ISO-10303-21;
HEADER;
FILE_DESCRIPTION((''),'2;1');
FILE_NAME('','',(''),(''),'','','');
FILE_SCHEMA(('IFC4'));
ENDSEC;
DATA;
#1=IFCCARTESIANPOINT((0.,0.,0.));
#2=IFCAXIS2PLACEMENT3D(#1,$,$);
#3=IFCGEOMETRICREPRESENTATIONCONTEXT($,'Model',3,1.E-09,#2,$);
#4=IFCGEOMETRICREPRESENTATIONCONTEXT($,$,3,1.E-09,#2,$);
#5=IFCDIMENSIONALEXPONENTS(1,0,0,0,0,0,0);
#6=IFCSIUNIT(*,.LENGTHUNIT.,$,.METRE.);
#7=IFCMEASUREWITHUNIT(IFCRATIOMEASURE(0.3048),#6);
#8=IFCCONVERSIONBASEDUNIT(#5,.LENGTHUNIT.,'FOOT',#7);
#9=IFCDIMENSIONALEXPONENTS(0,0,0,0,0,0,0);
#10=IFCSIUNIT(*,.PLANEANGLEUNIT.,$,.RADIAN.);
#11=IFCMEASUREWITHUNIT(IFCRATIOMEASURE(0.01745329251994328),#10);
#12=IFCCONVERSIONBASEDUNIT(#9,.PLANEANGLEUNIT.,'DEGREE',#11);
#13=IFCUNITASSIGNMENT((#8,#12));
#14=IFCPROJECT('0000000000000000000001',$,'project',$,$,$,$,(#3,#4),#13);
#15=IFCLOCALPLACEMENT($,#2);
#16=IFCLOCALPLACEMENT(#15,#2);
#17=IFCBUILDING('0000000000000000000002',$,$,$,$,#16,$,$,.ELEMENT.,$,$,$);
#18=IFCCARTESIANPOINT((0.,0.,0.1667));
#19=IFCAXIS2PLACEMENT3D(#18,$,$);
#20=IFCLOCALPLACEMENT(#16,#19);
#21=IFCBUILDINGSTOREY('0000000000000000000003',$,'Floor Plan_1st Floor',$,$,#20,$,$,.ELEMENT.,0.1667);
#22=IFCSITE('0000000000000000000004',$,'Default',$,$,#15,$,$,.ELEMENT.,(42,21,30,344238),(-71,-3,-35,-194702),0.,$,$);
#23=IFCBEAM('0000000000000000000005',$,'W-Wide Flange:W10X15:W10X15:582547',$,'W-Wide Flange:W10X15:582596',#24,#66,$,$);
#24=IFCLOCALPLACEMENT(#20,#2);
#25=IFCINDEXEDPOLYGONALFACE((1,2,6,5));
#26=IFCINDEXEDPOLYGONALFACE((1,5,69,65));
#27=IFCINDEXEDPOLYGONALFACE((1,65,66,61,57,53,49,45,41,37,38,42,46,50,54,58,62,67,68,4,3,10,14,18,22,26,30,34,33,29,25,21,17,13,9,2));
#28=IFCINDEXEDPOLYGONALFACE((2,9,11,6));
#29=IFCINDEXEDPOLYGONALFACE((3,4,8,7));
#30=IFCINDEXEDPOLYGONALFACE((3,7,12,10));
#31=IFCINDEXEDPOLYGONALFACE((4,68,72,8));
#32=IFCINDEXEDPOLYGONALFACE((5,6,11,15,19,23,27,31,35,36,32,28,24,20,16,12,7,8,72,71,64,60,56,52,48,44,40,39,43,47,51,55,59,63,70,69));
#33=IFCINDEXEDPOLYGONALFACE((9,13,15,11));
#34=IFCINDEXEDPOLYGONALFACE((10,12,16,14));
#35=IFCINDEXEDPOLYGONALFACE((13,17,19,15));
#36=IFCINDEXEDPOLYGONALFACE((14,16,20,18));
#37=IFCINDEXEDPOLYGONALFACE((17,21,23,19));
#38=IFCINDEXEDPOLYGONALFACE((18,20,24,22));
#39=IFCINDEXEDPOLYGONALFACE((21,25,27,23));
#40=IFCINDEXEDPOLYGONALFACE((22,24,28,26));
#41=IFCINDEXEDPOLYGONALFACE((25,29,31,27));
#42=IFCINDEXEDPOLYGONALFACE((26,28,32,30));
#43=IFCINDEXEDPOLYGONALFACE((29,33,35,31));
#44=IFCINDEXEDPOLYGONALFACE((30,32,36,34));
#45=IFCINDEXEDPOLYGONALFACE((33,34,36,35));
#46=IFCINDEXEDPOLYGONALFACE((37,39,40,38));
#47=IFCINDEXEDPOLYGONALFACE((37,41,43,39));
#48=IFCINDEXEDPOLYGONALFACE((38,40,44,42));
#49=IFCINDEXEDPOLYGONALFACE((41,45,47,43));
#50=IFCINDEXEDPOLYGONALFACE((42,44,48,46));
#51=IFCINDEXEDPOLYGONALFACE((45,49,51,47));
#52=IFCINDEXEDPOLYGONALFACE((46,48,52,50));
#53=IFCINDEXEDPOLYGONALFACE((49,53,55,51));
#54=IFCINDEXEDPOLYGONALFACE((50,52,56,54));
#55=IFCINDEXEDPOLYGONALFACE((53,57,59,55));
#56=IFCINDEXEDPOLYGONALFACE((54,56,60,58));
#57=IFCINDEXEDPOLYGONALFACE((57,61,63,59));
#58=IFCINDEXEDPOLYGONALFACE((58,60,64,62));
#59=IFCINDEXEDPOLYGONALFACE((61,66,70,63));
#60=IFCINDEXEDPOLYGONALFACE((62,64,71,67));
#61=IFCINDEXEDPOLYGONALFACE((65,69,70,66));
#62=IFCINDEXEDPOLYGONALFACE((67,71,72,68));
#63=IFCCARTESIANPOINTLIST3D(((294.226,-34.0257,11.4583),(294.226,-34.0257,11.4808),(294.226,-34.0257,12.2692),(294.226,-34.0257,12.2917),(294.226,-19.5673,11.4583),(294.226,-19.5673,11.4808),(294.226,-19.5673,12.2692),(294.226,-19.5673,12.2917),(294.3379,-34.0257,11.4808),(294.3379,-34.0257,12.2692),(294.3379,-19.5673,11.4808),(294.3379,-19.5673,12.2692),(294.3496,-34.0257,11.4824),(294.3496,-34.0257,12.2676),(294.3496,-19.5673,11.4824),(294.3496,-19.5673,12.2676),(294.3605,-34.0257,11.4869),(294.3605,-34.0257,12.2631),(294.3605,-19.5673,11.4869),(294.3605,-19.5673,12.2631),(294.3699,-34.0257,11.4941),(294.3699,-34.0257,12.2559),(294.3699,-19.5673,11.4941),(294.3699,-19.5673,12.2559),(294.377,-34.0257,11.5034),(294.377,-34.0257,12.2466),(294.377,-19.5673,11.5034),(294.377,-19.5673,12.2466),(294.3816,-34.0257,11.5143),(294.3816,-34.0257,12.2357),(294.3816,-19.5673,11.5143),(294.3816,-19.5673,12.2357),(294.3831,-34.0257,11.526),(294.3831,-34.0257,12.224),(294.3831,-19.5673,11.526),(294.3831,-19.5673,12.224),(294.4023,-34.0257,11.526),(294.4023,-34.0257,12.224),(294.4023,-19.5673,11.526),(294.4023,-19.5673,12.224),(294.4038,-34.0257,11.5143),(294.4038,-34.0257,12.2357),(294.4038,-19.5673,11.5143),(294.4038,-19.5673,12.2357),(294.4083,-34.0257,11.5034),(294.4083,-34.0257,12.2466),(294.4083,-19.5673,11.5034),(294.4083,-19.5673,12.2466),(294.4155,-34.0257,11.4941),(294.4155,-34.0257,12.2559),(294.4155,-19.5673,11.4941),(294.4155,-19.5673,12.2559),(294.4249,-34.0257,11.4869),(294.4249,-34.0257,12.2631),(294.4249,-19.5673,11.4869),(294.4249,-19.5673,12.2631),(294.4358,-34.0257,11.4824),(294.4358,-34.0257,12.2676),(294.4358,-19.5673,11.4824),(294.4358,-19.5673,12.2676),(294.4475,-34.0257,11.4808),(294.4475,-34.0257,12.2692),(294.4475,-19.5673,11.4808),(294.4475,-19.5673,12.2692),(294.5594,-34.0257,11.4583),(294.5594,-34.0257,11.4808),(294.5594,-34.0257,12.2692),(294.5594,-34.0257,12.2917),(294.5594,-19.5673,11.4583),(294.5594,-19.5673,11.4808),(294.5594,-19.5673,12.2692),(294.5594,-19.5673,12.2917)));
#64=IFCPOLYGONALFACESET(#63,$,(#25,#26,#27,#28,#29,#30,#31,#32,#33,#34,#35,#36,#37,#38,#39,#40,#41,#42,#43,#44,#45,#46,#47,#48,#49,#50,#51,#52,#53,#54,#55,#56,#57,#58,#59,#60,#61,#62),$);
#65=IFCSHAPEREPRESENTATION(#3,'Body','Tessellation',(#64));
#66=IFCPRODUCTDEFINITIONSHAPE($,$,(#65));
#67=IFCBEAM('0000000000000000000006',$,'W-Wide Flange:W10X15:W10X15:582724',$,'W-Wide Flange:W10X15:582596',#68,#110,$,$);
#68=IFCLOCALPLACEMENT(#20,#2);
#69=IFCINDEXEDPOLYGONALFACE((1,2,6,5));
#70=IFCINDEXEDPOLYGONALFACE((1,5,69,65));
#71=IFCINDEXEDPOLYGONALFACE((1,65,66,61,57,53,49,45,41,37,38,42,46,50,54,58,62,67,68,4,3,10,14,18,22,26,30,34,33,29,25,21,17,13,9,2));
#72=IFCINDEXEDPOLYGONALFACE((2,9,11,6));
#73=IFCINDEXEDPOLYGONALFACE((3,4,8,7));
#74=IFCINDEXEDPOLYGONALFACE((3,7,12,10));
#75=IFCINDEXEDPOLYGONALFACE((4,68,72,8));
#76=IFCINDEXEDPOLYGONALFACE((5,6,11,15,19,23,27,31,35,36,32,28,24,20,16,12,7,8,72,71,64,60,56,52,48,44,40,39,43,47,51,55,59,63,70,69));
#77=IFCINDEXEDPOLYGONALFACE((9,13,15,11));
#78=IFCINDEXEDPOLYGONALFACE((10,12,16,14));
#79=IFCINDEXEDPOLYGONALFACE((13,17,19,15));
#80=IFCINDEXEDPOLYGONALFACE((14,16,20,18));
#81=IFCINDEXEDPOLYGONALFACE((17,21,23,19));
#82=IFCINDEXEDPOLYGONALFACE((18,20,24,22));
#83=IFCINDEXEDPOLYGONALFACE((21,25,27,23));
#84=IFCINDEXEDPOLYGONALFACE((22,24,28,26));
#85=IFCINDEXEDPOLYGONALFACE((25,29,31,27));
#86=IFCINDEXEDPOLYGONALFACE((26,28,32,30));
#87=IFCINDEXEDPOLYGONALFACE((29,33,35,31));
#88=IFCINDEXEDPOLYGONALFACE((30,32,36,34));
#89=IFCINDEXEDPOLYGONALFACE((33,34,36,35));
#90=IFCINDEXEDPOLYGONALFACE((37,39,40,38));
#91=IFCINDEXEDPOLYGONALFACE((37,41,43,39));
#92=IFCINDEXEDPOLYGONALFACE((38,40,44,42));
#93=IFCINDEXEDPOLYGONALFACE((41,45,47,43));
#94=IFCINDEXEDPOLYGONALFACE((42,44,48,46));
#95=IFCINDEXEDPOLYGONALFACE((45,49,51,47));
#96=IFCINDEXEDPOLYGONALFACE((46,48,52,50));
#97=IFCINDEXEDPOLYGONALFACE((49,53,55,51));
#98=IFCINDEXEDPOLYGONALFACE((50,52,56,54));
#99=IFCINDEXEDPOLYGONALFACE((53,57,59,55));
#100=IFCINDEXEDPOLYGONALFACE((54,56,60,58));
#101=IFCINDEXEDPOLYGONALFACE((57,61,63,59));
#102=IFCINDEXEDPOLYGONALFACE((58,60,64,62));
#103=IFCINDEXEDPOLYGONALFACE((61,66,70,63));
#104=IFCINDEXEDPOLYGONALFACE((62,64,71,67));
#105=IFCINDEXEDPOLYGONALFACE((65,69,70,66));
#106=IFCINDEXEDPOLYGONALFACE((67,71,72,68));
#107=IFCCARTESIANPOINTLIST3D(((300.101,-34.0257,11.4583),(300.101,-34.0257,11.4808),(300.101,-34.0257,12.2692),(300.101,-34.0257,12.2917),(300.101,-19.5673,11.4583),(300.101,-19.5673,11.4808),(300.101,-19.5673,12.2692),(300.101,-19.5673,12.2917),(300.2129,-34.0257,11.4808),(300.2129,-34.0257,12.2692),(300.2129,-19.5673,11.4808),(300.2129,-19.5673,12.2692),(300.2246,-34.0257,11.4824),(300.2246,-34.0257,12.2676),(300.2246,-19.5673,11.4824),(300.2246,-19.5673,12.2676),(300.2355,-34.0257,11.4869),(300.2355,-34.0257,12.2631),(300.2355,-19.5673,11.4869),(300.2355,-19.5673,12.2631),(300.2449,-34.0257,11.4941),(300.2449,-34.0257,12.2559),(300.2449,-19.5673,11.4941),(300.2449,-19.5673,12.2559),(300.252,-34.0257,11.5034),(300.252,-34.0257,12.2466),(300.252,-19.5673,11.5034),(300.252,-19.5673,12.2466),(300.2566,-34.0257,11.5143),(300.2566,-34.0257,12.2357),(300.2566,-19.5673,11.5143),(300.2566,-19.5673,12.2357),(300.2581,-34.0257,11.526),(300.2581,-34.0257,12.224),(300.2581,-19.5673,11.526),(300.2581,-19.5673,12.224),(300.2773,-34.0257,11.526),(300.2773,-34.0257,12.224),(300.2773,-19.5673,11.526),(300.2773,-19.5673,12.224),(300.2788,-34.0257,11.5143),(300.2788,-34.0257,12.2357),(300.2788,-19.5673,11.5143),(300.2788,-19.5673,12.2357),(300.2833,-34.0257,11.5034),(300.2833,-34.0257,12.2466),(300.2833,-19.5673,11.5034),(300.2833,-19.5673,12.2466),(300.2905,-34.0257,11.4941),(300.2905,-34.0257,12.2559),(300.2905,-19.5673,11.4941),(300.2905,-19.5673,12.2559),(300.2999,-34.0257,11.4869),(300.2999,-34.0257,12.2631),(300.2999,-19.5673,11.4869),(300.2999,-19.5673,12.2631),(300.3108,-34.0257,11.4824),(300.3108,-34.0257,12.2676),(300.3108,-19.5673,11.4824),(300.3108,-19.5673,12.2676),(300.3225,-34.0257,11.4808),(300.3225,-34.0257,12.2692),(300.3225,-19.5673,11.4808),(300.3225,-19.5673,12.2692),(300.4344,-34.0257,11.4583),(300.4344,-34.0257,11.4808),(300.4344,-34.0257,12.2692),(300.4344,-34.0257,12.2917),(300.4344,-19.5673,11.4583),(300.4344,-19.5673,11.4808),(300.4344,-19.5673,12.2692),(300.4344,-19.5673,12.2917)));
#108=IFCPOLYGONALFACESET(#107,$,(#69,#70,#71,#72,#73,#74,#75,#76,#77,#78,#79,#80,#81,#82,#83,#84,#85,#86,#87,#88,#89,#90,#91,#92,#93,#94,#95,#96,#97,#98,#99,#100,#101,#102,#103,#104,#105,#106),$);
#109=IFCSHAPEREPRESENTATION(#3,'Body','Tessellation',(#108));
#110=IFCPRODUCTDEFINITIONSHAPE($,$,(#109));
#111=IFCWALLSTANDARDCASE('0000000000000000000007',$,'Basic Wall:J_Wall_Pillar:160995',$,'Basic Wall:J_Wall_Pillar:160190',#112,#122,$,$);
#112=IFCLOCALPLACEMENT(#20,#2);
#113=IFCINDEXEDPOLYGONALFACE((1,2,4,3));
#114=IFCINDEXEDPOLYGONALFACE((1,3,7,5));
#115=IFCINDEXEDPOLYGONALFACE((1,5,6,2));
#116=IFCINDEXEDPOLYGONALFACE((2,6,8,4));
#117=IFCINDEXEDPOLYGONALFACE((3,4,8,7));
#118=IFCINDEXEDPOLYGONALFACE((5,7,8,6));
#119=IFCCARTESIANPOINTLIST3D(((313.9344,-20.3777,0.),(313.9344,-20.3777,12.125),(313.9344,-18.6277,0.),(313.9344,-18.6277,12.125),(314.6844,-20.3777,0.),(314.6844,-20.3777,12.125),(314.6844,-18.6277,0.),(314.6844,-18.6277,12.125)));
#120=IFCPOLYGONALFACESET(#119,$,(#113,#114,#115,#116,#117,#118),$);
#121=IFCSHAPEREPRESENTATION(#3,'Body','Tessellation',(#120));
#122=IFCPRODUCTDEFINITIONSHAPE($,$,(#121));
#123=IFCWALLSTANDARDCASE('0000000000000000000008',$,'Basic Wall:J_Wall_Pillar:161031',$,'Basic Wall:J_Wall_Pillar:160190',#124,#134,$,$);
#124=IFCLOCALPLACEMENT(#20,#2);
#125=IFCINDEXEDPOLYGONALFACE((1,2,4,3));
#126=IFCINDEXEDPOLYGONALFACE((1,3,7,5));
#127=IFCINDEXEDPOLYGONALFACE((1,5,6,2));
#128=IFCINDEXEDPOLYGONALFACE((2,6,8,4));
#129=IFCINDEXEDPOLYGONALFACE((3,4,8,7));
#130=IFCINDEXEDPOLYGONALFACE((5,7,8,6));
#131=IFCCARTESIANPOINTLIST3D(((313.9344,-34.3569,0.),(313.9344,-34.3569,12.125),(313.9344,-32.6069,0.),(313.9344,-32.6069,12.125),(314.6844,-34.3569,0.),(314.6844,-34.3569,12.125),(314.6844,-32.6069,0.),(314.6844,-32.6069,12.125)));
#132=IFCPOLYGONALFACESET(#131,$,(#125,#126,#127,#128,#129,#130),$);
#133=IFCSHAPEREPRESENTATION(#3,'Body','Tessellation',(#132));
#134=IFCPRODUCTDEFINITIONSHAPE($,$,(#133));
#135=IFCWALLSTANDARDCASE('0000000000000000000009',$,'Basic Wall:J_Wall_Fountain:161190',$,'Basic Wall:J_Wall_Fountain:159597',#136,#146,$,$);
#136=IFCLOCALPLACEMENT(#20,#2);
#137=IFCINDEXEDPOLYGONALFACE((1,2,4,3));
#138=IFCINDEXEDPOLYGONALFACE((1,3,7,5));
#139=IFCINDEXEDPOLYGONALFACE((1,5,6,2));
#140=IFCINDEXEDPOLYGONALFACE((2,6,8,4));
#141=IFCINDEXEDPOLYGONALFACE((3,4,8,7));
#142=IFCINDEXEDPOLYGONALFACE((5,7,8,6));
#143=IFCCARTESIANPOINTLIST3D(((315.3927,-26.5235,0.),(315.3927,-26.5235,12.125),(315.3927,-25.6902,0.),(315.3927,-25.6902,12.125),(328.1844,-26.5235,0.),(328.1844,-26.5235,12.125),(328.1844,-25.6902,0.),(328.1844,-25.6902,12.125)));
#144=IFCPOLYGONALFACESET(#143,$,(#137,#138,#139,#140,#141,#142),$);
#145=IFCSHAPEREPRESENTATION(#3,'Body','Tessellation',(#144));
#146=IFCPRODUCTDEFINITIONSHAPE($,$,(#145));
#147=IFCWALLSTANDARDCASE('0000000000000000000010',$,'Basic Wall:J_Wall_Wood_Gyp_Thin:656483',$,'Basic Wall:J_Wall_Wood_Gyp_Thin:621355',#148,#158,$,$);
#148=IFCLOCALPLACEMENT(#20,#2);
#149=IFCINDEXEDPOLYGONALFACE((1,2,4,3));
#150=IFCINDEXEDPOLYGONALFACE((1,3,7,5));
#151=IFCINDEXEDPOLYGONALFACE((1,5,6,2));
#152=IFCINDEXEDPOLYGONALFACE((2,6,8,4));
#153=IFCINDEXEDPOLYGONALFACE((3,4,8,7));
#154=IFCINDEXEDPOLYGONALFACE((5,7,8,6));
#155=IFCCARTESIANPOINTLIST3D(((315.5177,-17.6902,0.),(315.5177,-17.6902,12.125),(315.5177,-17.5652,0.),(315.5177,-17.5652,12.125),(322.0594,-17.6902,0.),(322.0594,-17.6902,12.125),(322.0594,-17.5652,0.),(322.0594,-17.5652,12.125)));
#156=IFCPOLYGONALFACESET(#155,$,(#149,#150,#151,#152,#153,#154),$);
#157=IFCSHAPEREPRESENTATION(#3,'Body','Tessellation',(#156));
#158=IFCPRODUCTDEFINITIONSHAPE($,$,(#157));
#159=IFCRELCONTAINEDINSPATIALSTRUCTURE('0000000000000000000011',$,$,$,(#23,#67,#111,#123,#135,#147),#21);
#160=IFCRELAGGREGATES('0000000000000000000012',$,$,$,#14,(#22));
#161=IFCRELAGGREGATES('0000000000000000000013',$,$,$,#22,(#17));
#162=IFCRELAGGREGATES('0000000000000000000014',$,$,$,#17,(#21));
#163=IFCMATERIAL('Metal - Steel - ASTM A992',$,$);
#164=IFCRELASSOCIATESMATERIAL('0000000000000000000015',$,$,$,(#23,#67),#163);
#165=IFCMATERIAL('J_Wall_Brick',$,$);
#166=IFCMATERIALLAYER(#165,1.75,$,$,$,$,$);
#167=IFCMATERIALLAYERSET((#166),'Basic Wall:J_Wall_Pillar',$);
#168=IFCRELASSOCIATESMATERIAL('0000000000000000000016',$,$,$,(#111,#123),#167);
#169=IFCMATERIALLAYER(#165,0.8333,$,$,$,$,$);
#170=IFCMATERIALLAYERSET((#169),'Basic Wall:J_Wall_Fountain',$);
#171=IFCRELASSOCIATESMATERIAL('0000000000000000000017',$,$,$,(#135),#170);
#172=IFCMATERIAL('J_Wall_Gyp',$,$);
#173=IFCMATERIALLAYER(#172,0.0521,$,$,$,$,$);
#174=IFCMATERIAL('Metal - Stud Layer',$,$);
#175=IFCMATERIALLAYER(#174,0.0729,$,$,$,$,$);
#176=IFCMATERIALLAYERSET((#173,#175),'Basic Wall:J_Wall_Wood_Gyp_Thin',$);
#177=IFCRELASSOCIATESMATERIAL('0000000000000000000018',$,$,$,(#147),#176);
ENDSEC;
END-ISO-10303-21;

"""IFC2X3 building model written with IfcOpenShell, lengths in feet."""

from ifc_helpers import new_model, entity, si_unit, converted_unit, frame, frame_2d, origin, place, context, project, spatial, polyline, circle_curve, parameter, trimmed, segment, composite_curve, rectangle, outline, extrude, clip, halfspace, material, layer, layer_set, layer_usage, element, save


model = new_model("IFC2X3")

# Units and contexts
model_context = context("Model", 3, precision=1e-09, world=origin())
context_of_model = context(None, 3, precision=1e-09, world=origin())
ifc_project = project(units=[converted_unit("LENGTHUNIT", "FOOT", entity("IfcRatioMeasure", 0.3048), si_unit("LENGTHUNIT", "METRE"), dimensions=[1, 0, 0, 0, 0, 0, 0]), converted_unit("PLANEANGLEUNIT", "DEGREE", entity("IfcRatioMeasure", 0.01745329251994328), si_unit("PLANEANGLEUNIT", "RADIAN"), dimensions=[0, 0, 0, 0, 0, 0, 0])], contexts=[model_context, context_of_model])

# Site, building, storey
site_placement = place(None, origin())
site = spatial("IfcSite", under=ifc_project, at=site_placement, Name="Default", CompositionType="ELEMENT", RefLatitude=(42, 21, 30, 344238), RefLongitude=(-71, -3, -35, -194702), RefElevation=0.0)
building_placement = place(site_placement, origin())
building = spatial("IfcBuilding", under=site, at=building_placement, CompositionType="ELEMENT")
storey_placement = place(building_placement, frame((0.0, 0.0, 0.1667)))
storey = spatial("IfcBuildingStorey", under=building, at=storey_placement, Name="Floor Plan_1st Floor", CompositionType="ELEMENT", Elevation=0.1667)

# Beams
ifc_material_1 = material(Name="Metal - Steel - ASTM A992")
beam_1_placement = place(storey_placement, frame((294.3927, -33.3748, 12.2917)))
element("IfcBeam", 1, at=beam_1_placement, inside=storey, material=ifc_material_1, Name="W-Wide Flange:W10X15:W10X15:582547", ObjectType="W-Wide Flange:W10X15:582596", context=model_context, shape_type="SweptSolid", body=[
    extrude(outline(composite_curve([segment(polyline([(-0.1667, -0.3942), (-0.1667, -0.4167)]), True, "CONTINUOUS"), segment(polyline([(-0.1667, -0.4167), (0.1667, -0.4167)]), True, "CONTINUOUS"), segment(polyline([(0.1667, -0.4167), (0.1667, -0.3942)]), True, "CONTINUOUS"), segment(polyline([(0.1667, -0.3942), (0.0548, -0.3942)]), True, "CONTINUOUS"), segment(trimmed(circle_curve(frame_2d((0.0548, -0.349), x_axis=(1.0, 0.0)), 0.0452), [parameter(180.0)], [parameter(270.0)], True, "PARAMETER"), False, "CONTINUOUS"), segment(polyline([(0.0096, -0.349), (0.0096, 0.349)]), True, "CONTINUOUS"), segment(trimmed(circle_curve(frame_2d((0.0548, 0.349), x_axis=(1.0, 0.0)), 0.0452), [parameter(90.0)], [parameter(180.0)], True, "PARAMETER"), False, "CONTINUOUS"), segment(polyline([(0.0548, 0.3942), (0.1667, 0.3942)]), True, "CONTINUOUS"), segment(polyline([(0.1667, 0.3942), (0.1667, 0.4167)]), True, "CONTINUOUS"), segment(polyline([(0.1667, 0.4167), (-0.1667, 0.4167)]), True, "CONTINUOUS"), segment(polyline([(-0.1667, 0.4167), (-0.1667, 0.3942)]), True, "CONTINUOUS"), segment(polyline([(-0.1667, 0.3942), (-0.0548, 0.3942)]), True, "CONTINUOUS"), segment(trimmed(circle_curve(frame_2d((-0.0548, 0.349), x_axis=(1.0, 0.0)), 0.0452), [parameter(360.0)], [parameter(90.0)], True, "PARAMETER"), False, "CONTINUOUS"), segment(polyline([(-0.0096, 0.349), (-0.0096, -0.349)]), True, "CONTINUOUS"), segment(trimmed(circle_curve(frame_2d((-0.0548, -0.349), x_axis=(1.0, 0.0)), 0.0452), [parameter(270.0)], [parameter(360.0)], True, "PARAMETER"), False, "CONTINUOUS"), segment(polyline([(-0.0548, -0.3942), (-0.1667, -0.3942)]), True, "CONTINUOUS")], self_intersect=False)), frame((0.0, -0.6509, -0.4167), z_axis=(0.0, -1.0, 0.0), x_axis=(1.0, 0.0, 0.0)), (0.0, 0.0, -1.0), 14.4583),
])
beam_2_placement = place(storey_placement, frame((300.2677, -33.3748, 12.2917)))
element("IfcBeam", 2, at=beam_2_placement, inside=storey, material=ifc_material_1, Name="W-Wide Flange:W10X15:W10X15:582724", ObjectType="W-Wide Flange:W10X15:582596", context=model_context, shape_type="SweptSolid", body=[
    extrude(outline(composite_curve([segment(polyline([(-0.1667, -0.3942), (-0.1667, -0.4167)]), True, "CONTINUOUS"), segment(polyline([(-0.1667, -0.4167), (0.1667, -0.4167)]), True, "CONTINUOUS"), segment(polyline([(0.1667, -0.4167), (0.1667, -0.3942)]), True, "CONTINUOUS"), segment(polyline([(0.1667, -0.3942), (0.0548, -0.3942)]), True, "CONTINUOUS"), segment(trimmed(circle_curve(frame_2d((0.0548, -0.349), x_axis=(1.0, 0.0)), 0.0452), [parameter(180.0)], [parameter(270.0)], True, "PARAMETER"), False, "CONTINUOUS"), segment(polyline([(0.0096, -0.349), (0.0096, 0.349)]), True, "CONTINUOUS"), segment(trimmed(circle_curve(frame_2d((0.0548, 0.349), x_axis=(1.0, 0.0)), 0.0452), [parameter(90.0)], [parameter(180.0)], True, "PARAMETER"), False, "CONTINUOUS"), segment(polyline([(0.0548, 0.3942), (0.1667, 0.3942)]), True, "CONTINUOUS"), segment(polyline([(0.1667, 0.3942), (0.1667, 0.4167)]), True, "CONTINUOUS"), segment(polyline([(0.1667, 0.4167), (-0.1667, 0.4167)]), True, "CONTINUOUS"), segment(polyline([(-0.1667, 0.4167), (-0.1667, 0.3942)]), True, "CONTINUOUS"), segment(polyline([(-0.1667, 0.3942), (-0.0548, 0.3942)]), True, "CONTINUOUS"), segment(trimmed(circle_curve(frame_2d((-0.0548, 0.349), x_axis=(1.0, 0.0)), 0.0452), [parameter(360.0)], [parameter(90.0)], True, "PARAMETER"), False, "CONTINUOUS"), segment(polyline([(-0.0096, 0.349), (-0.0096, -0.349)]), True, "CONTINUOUS"), segment(trimmed(circle_curve(frame_2d((-0.0548, -0.349), x_axis=(1.0, 0.0)), 0.0452), [parameter(270.0)], [parameter(360.0)], True, "PARAMETER"), False, "CONTINUOUS"), segment(polyline([(-0.0548, -0.3942), (-0.1667, -0.3942)]), True, "CONTINUOUS")], self_intersect=False)), frame((0.0, -0.6509, -0.4167), z_axis=(0.0, -1.0, 0.0), x_axis=(1.0, 0.0, 0.0)), (0.0, 0.0, -1.0), 14.4583),
])

# Walls
ifc_material_2 = material(Name="J_Wall_Brick")
ifc_layer_1 = layer(ifc_material_2, 1.75)
ifc_layer_set_1 = layer_set([ifc_layer_1], Name="Basic Wall:J_Wall_Pillar")
ifc_layer_usage_1 = layer_usage(ifc_layer_set_1, "AXIS2", "NEGATIVE", 0.875)
wall_1_placement = place(storey_placement, frame((314.6844, -19.5027, 0.0), z_axis=(0.0, 0.0, 1.0), x_axis=(-1.0, 0.0, 0.0)))
element("IfcWallStandardCase", 3, at=wall_1_placement, inside=storey, material=ifc_layer_usage_1, Name="Basic Wall:J_Wall_Pillar:160995", ObjectType="Basic Wall:J_Wall_Pillar:160190", context=model_context, shape_type="Clipping", body=[
    clip(extrude(rectangle(XDim=0.75, YDim=1.75, at=frame_2d((0.375, 0.0), x_axis=(-1.0, 0.0))), origin(), (0.0, 0.0, 1.0), 12.125), halfspace(origin(), True)),
])
ifc_layer_usage_2 = layer_usage(ifc_layer_set_1, "AXIS2", "NEGATIVE", 0.875)
wall_2_placement = place(storey_placement, frame((314.6844, -33.4819, 0.0), z_axis=(0.0, 0.0, 1.0), x_axis=(-1.0, 0.0, 0.0)))
element("IfcWallStandardCase", 4, at=wall_2_placement, inside=storey, material=ifc_layer_usage_2, Name="Basic Wall:J_Wall_Pillar:161031", ObjectType="Basic Wall:J_Wall_Pillar:160190", context=model_context, shape_type="Clipping", body=[
    clip(extrude(rectangle(XDim=0.75, YDim=1.75, at=frame_2d((0.375, 0.0), x_axis=(-1.0, 0.0))), origin(), (0.0, 0.0, 1.0), 12.125), halfspace(origin(), True)),
])
ifc_layer_2 = layer(ifc_material_2, 0.8333)
ifc_layer_set_2 = layer_set([ifc_layer_2], Name="Basic Wall:J_Wall_Fountain")
ifc_layer_usage_3 = layer_usage(ifc_layer_set_2, "AXIS2", "NEGATIVE", 0.4167)
wall_3_placement = place(storey_placement, frame((315.3927, -26.1069, 0.0)))
element("IfcWallStandardCase", 5, at=wall_3_placement, inside=storey, material=ifc_layer_usage_3, Name="Basic Wall:J_Wall_Fountain:161190", ObjectType="Basic Wall:J_Wall_Fountain:159597", context=model_context, shape_type="SweptSolid", body=[
    extrude(rectangle(XDim=12.7917, YDim=0.8333, at=frame_2d((6.3958, 0.0), x_axis=(-1.0, 0.0))), origin(), (0.0, 0.0, 1.0), 12.125),
])
ifc_material_3 = material(Name="J_Wall_Gyp")
ifc_layer_3 = layer(ifc_material_3, 0.0521)
ifc_material_4 = material(Name="Metal - Stud Layer")
ifc_layer_4 = layer(ifc_material_4, 0.0729)
ifc_layer_set_3 = layer_set([ifc_layer_3, ifc_layer_4], Name="Basic Wall:J_Wall_Wood_Gyp_Thin")
ifc_layer_usage_4 = layer_usage(ifc_layer_set_3, "AXIS2", "NEGATIVE", 0.0625)
wall_4_placement = place(storey_placement, frame((315.5177, -17.6277, 0.0)))
element("IfcWallStandardCase", 6, at=wall_4_placement, inside=storey, material=ifc_layer_usage_4, Name="Basic Wall:J_Wall_Wood_Gyp_Thin:656483", ObjectType="Basic Wall:J_Wall_Wood_Gyp_Thin:621355", context=model_context, shape_type="Clipping", body=[
    clip(extrude(rectangle(XDim=6.5417, YDim=0.125, at=frame_2d((3.2708, 0.0), x_axis=(-1.0, 0.0))), origin(), (0.0, 0.0, 1.0), 12.125), halfspace(origin(), True)),
])

save(model, "model.ifc")
